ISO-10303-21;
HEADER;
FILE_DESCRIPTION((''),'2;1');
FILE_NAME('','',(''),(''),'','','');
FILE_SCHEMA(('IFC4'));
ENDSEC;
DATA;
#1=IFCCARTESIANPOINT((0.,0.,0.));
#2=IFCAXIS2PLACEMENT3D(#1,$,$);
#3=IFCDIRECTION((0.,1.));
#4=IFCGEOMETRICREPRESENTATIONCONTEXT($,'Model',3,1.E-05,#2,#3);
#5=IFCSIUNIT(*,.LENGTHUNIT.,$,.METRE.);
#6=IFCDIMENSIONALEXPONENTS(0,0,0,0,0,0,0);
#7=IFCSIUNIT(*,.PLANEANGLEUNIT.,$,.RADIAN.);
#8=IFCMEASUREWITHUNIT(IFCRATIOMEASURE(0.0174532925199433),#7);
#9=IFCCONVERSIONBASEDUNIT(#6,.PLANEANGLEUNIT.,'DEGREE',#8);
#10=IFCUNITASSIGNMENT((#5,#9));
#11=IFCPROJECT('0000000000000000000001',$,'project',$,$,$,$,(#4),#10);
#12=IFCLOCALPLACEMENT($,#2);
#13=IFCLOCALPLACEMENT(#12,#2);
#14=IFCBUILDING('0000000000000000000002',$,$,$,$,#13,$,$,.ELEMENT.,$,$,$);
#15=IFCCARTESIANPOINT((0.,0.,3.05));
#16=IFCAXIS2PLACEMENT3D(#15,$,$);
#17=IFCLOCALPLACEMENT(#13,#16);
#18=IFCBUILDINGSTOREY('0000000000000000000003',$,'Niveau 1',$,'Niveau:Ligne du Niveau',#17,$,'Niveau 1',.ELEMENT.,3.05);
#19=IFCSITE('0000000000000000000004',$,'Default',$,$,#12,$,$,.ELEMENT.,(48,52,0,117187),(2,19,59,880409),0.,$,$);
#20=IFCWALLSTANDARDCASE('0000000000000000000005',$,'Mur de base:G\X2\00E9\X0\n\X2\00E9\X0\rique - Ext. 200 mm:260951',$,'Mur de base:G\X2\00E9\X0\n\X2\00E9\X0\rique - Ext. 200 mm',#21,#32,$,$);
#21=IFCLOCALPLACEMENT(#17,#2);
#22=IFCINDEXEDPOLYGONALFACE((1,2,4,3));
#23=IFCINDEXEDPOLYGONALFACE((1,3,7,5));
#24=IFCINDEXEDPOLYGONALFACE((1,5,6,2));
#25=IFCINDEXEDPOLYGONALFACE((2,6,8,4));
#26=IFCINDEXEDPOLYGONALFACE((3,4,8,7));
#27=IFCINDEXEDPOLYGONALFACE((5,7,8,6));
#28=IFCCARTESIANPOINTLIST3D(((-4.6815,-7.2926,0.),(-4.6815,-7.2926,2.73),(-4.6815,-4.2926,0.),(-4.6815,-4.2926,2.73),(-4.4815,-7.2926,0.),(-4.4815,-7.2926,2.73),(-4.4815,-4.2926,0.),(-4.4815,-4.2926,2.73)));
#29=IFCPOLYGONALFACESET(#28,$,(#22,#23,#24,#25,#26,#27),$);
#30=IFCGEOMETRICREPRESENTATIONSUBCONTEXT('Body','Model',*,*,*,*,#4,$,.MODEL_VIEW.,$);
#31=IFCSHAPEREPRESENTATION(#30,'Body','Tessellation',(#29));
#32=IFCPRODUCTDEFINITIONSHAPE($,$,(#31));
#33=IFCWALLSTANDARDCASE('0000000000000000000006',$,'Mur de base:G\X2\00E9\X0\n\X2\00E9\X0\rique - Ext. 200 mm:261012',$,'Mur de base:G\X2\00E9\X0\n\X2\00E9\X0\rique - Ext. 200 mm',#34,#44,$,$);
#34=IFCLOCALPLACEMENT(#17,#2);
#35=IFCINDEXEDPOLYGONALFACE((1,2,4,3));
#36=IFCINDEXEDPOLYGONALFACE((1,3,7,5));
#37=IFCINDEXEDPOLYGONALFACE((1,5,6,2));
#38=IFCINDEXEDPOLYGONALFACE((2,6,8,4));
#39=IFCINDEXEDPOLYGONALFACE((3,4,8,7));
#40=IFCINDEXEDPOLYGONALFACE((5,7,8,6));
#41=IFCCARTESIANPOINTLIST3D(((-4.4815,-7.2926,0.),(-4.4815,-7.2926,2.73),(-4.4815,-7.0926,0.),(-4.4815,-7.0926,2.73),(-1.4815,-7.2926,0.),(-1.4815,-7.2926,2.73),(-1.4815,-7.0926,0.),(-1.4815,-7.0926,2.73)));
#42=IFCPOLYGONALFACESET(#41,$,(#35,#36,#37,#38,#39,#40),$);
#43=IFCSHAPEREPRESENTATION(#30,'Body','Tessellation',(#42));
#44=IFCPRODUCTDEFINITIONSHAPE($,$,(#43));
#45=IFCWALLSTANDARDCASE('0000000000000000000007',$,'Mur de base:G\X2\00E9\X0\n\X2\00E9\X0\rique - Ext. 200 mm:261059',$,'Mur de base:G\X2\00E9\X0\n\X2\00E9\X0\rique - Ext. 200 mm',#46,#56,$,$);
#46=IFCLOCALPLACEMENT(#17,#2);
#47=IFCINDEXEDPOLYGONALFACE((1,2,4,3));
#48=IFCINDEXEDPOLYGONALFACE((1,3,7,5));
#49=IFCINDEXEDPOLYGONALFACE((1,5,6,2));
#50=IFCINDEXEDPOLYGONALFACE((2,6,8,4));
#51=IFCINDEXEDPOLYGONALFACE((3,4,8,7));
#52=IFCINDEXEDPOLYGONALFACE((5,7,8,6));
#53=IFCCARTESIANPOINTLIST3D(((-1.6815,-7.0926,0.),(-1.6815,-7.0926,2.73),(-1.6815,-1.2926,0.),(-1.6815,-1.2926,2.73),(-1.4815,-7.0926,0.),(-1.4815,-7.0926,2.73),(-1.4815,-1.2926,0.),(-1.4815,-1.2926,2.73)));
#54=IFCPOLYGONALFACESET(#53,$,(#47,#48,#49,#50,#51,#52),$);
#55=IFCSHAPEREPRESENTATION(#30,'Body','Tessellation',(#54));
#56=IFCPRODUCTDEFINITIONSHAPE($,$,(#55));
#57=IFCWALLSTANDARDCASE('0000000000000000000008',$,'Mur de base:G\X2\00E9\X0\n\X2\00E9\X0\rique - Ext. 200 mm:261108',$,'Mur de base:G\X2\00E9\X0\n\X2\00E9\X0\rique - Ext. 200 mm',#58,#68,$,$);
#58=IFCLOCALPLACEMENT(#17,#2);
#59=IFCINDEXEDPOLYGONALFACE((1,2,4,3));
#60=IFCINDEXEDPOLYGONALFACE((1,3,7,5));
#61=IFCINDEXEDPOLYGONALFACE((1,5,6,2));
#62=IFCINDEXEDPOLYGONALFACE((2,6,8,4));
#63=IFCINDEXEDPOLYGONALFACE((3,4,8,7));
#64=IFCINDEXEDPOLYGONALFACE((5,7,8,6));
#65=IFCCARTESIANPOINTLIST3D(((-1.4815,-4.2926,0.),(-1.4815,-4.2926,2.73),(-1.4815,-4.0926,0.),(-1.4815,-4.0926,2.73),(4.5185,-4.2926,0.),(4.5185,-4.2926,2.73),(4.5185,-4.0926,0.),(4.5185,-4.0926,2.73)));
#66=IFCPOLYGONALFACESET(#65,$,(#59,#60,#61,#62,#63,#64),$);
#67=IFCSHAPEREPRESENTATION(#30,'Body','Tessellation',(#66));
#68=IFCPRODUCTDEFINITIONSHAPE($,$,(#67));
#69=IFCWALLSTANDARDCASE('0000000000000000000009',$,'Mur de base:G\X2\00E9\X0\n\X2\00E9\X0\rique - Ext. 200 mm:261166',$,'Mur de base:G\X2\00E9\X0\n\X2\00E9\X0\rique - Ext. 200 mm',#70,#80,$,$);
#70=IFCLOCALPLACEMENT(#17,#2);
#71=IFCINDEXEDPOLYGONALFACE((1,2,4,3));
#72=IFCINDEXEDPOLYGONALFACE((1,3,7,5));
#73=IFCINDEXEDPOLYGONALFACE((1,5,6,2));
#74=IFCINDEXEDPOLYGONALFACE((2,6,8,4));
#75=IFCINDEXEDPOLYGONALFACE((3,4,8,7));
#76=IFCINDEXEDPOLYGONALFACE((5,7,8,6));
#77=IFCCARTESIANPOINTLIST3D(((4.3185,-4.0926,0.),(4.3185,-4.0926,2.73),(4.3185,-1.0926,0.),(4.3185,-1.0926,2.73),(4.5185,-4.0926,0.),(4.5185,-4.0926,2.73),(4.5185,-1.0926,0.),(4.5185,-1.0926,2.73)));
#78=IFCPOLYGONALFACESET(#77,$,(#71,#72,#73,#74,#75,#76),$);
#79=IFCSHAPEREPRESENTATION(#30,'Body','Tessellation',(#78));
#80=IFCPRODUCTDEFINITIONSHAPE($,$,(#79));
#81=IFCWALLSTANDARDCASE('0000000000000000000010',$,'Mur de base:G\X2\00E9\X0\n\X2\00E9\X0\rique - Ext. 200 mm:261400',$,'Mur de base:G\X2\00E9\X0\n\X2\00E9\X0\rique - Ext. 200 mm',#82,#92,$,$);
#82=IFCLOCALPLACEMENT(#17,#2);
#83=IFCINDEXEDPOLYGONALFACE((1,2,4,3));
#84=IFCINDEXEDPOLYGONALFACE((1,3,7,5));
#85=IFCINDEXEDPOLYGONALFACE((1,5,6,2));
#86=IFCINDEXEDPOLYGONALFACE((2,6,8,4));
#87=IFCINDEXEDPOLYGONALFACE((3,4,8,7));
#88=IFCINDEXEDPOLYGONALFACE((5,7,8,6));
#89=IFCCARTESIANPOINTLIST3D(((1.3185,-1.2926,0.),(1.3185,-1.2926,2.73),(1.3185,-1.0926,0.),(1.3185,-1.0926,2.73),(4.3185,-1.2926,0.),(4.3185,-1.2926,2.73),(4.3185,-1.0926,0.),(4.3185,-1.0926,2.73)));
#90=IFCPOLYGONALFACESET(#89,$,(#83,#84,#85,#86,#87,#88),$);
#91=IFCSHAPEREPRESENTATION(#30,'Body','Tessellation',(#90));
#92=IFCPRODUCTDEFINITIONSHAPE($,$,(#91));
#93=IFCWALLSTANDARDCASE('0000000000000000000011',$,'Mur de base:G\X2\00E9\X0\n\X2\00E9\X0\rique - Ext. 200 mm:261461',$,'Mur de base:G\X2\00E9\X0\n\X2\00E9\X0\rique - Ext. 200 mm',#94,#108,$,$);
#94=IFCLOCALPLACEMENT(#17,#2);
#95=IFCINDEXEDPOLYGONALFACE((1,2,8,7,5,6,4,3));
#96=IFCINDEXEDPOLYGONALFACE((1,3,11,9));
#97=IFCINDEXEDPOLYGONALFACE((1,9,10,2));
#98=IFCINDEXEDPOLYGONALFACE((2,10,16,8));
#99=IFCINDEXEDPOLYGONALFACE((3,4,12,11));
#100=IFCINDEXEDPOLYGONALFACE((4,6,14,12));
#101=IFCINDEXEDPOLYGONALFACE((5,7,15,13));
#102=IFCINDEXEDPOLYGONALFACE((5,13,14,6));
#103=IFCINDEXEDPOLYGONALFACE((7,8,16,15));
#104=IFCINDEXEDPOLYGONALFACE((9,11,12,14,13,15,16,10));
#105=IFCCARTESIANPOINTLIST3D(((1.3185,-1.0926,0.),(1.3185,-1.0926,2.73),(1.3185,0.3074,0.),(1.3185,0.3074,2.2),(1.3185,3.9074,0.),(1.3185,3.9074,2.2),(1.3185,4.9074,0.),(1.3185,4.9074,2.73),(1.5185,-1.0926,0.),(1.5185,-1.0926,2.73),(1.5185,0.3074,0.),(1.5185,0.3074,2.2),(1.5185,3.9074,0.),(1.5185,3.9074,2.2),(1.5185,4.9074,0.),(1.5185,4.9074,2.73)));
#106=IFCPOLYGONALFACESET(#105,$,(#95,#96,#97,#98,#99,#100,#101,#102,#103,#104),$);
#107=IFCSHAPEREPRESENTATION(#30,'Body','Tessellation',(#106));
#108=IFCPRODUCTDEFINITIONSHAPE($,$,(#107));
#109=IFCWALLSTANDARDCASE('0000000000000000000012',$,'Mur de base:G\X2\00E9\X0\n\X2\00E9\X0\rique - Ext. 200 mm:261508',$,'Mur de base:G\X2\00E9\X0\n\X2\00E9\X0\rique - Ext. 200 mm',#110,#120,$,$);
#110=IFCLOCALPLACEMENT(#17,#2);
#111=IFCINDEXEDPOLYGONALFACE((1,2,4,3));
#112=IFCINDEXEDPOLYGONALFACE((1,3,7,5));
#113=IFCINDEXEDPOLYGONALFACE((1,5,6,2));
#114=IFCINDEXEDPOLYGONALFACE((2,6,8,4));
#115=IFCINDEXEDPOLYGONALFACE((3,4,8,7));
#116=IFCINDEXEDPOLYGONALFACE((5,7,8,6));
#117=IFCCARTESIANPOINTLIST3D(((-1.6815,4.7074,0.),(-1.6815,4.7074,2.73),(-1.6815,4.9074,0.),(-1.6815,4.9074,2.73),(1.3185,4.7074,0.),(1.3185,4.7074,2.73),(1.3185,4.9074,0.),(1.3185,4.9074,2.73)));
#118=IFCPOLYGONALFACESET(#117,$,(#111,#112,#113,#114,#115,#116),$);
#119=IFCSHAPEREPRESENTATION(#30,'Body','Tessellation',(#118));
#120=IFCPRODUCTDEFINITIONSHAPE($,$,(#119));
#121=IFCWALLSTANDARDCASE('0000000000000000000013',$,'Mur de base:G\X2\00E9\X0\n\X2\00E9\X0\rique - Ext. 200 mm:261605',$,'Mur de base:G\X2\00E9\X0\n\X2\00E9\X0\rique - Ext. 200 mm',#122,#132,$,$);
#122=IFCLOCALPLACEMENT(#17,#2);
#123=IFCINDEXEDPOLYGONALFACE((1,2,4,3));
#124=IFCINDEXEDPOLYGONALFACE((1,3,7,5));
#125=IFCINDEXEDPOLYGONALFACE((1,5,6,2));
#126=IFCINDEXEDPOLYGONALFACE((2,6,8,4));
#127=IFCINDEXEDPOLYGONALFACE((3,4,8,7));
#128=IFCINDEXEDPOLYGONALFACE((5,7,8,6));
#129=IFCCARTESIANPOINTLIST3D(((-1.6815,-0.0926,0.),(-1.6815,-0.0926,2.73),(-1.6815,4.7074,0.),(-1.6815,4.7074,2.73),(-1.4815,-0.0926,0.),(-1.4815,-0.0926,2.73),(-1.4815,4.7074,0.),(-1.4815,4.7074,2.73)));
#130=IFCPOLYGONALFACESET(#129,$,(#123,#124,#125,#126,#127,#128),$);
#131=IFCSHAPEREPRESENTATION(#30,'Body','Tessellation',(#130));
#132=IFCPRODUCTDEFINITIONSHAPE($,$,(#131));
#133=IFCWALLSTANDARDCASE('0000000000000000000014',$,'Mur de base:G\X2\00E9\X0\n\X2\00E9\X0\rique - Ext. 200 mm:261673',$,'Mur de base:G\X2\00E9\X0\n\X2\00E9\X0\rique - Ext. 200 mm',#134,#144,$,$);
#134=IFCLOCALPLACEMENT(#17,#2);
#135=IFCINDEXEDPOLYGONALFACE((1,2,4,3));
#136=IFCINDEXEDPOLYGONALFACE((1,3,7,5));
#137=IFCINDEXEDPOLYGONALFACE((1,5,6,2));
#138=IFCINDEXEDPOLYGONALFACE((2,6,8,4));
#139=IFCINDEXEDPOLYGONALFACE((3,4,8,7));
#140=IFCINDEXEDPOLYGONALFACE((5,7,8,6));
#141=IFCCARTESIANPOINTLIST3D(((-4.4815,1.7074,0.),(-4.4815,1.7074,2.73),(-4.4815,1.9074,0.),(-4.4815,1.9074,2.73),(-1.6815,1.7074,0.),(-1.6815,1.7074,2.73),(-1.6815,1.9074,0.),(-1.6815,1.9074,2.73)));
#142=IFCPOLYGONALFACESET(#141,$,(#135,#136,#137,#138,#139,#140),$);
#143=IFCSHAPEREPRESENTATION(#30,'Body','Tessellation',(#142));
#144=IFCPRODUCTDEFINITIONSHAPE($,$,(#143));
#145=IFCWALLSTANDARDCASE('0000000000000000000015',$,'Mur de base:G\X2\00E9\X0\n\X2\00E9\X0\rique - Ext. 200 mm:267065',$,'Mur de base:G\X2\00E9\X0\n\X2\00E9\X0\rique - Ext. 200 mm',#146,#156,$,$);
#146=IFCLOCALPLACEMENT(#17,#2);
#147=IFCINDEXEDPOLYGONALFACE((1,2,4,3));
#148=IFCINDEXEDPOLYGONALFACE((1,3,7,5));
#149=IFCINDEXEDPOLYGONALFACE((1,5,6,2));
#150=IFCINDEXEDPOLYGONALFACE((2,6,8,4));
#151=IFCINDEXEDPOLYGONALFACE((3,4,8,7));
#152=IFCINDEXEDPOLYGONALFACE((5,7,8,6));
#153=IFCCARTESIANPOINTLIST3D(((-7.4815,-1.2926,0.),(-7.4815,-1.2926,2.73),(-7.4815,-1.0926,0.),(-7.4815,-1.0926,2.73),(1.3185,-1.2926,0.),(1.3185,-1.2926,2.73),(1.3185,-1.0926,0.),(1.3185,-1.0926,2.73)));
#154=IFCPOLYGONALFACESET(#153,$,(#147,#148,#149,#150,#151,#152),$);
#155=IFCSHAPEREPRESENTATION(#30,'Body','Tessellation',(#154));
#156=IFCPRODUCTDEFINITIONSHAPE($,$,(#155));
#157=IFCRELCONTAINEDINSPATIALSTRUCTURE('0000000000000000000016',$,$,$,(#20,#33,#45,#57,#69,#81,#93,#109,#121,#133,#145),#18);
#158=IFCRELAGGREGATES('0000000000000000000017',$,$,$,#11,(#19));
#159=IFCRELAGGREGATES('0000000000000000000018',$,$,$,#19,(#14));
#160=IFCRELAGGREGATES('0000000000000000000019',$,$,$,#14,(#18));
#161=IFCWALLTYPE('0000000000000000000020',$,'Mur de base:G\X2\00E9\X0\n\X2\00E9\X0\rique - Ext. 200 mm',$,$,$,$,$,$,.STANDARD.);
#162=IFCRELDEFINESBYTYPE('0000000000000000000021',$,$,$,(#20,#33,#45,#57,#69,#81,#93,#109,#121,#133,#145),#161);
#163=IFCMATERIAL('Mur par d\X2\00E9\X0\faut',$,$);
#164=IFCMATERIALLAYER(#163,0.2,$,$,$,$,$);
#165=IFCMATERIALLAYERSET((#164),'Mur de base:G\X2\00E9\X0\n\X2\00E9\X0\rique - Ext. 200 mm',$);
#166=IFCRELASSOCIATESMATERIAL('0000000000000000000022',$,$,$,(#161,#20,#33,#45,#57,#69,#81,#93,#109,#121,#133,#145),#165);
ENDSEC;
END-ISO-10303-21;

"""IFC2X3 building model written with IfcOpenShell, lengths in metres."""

from ifc_helpers import new_model, entity, si_unit, converted_unit, direction, frame, frame_2d, origin, place, context, subcontext, project, spatial, polyline, rectangle, extrude, clip, bounded_halfspace, material, layer, layer_set, layer_usage, type_object, element, save


model = new_model("IFC2X3")

# Units and contexts
model_context = context("Model", 3, precision=1e-05, world=origin(), true_north=direction((0.0, 1.0)))
body_context = subcontext(model_context, "Body", "Model", "MODEL_VIEW")
ifc_project = project(units=[si_unit("LENGTHUNIT", "METRE"), converted_unit("PLANEANGLEUNIT", "DEGREE", entity("IfcRatioMeasure", 0.0174532925199433), si_unit("PLANEANGLEUNIT", "RADIAN"), dimensions=[0, 0, 0, 0, 0, 0, 0])], contexts=[model_context])

# Site, building, storey
site_placement = place(None, origin())
site = spatial("IfcSite", under=ifc_project, at=site_placement, Name="Default", CompositionType="ELEMENT", RefLatitude=(48, 52, 0, 117187), RefLongitude=(2, 19, 59, 880409), RefElevation=0.0)
building_placement = place(site_placement, origin())
building = spatial("IfcBuilding", under=site, at=building_placement, CompositionType="ELEMENT")
storey_placement = place(building_placement, frame((0.0, 0.0, 3.05)))
storey = spatial("IfcBuildingStorey", under=building, at=storey_placement, Name="Niveau 1", ObjectType="Niveau:Ligne du Niveau", LongName="Niveau 1", CompositionType="ELEMENT", Elevation=3.05)

# Walls
ifc_material_1 = material(Name="Mur par défaut")
ifc_layer_1 = layer(ifc_material_1, 0.2)
ifc_layer_set_1 = layer_set([ifc_layer_1], Name="Mur de base:Générique - Ext. 200 mm")
wall_type = type_object("IfcWallType", Name="Mur de base:Générique - Ext. 200 mm", PredefinedType="STANDARD", material=ifc_layer_set_1)
ifc_layer_usage_1 = layer_usage(ifc_layer_set_1, "AXIS2", "NEGATIVE", 0.1)
wall_1_placement = place(storey_placement, frame((-4.5815, -4.2926, 0.0), z_axis=(0.0, 0.0, 1.0), x_axis=(0.0, -1.0, 0.0)))
element("IfcWallStandardCase", 1, at=wall_1_placement, inside=storey, type_object=wall_type, material=ifc_layer_usage_1, Name="Mur de base:Générique - Ext. 200 mm:260951", ObjectType="Mur de base:Générique - Ext. 200 mm", context=body_context, shape_type="Clipping", body=[
    clip(extrude(rectangle(XDim=3.0, YDim=0.2, at=frame_2d((1.5, 0.0), x_axis=(-1.0, 0.0))), origin(), (0.0, 0.0, 1.0), 2.73), bounded_halfspace(frame((0.0, -0.1, 2.73), z_axis=(0.0, 0.0, -1.0), x_axis=(0.0, 1.0, 0.0)), True, frame((0.0, -0.1, 2.73)), polyline([(0.0, 0.0), (3.0, 0.0), (3.0, 0.2), (2.8, 0.2), (0.0, 0.2), (0.0, 0.0)]))),
])
ifc_layer_usage_2 = layer_usage(ifc_layer_set_1, "AXIS2", "NEGATIVE", 0.1)
wall_2_placement = place(storey_placement, frame((-4.4815, -7.1926, 0.0)))
element("IfcWallStandardCase", 2, at=wall_2_placement, inside=storey, type_object=wall_type, material=ifc_layer_usage_2, Name="Mur de base:Générique - Ext. 200 mm:261012", ObjectType="Mur de base:Générique - Ext. 200 mm", context=body_context, shape_type="Clipping", body=[
    clip(extrude(rectangle(XDim=3.0, YDim=0.2, at=frame_2d((1.5, 0.0), x_axis=(-1.0, 0.0))), origin(), (0.0, 0.0, 1.0), 2.73), bounded_halfspace(frame((0.0, -0.1, 2.73), z_axis=(0.0, 0.0, -1.0), x_axis=(1.0, 0.0, 0.0)), True, frame((0.0, -0.1, 2.73)), polyline([(0.0, 0.0), (3.0, 0.0), (3.0, 0.2), (2.8, 0.2), (0.0, 0.2), (0.0, 0.0)]))),
])
ifc_layer_usage_3 = layer_usage(ifc_layer_set_1, "AXIS2", "NEGATIVE", 0.1)
wall_3_placement = place(storey_placement, frame((-1.5815, -7.0926, 0.0), z_axis=(0.0, 0.0, 1.0), x_axis=(0.0, 1.0, 0.0)))
element("IfcWallStandardCase", 3, at=wall_3_placement, inside=storey, type_object=wall_type, material=ifc_layer_usage_3, Name="Mur de base:Générique - Ext. 200 mm:261059", ObjectType="Mur de base:Générique - Ext. 200 mm", context=body_context, shape_type="Clipping", body=[
    clip(extrude(rectangle(XDim=5.8, YDim=0.2, at=frame_2d((2.9, 0.0), x_axis=(-1.0, 0.0))), origin(), (0.0, 0.0, 1.0), 2.73), bounded_halfspace(frame((0.0, -0.1, 2.73), z_axis=(0.0, 0.0, -1.0), x_axis=(0.0, -1.0, 0.0)), True, frame((0.0, -0.1, 2.73)), polyline([(0.0, 0.0), (2.6633, 0.0), (2.8, 0.0), (3.0, 0.0), (5.8, 0.0), (5.8, 0.2), (0.0, 0.2), (0.0, 0.0)]))),
])
ifc_layer_usage_4 = layer_usage(ifc_layer_set_1, "AXIS2", "NEGATIVE", 0.1)
wall_4_placement = place(storey_placement, frame((-1.4815, -4.1926, 0.0)))
element("IfcWallStandardCase", 4, at=wall_4_placement, inside=storey, type_object=wall_type, material=ifc_layer_usage_4, Name="Mur de base:Générique - Ext. 200 mm:261108", ObjectType="Mur de base:Générique - Ext. 200 mm", context=body_context, shape_type="Clipping", body=[
    clip(extrude(rectangle(XDim=6.0, YDim=0.2, at=frame_2d((3.0, 0.0), x_axis=(-1.0, 0.0))), origin(), (0.0, 0.0, 1.0), 2.73), bounded_halfspace(frame((0.0, -0.1, 2.73), z_axis=(0.0, 0.0, -1.0), x_axis=(1.0, 0.0, 0.0)), True, frame((0.0, -0.1, 2.73)), polyline([(0.0, 0.0), (1.0152, 0.0), (6.0, 0.0), (6.0, 0.2), (5.8, 0.2), (0.0, 0.2), (0.0, 0.0)]))),
])
ifc_layer_usage_5 = layer_usage(ifc_layer_set_1, "AXIS2", "NEGATIVE", 0.1)
wall_5_placement = place(storey_placement, frame((4.4185, -4.0926, 0.0), z_axis=(0.0, 0.0, 1.0), x_axis=(0.0, 1.0, 0.0)))
element("IfcWallStandardCase", 5, at=wall_5_placement, inside=storey, type_object=wall_type, material=ifc_layer_usage_5, Name="Mur de base:Générique - Ext. 200 mm:261166", ObjectType="Mur de base:Générique - Ext. 200 mm", context=body_context, shape_type="Clipping", body=[
    clip(extrude(rectangle(XDim=3.0, YDim=0.2, at=frame_2d((1.5, 0.0), x_axis=(-1.0, 0.0))), origin(), (0.0, 0.0, 1.0), 2.73), bounded_halfspace(frame((0.0, -0.1, 2.73), z_axis=(0.0, 0.0, -1.0), x_axis=(0.0, -1.0, 0.0)), True, frame((0.0, -0.1, 2.73)), polyline([(0.0, 0.0), (3.0, 0.0), (3.0, 0.2), (2.8, 0.2), (0.0, 0.2), (0.0, 0.0)]))),
])
ifc_layer_usage_6 = layer_usage(ifc_layer_set_1, "AXIS2", "NEGATIVE", 0.1)
wall_6_placement = place(storey_placement, frame((4.3185, -1.1926, 0.0), z_axis=(0.0, 0.0, 1.0), x_axis=(-1.0, 0.0, 0.0)))
element("IfcWallStandardCase", 6, at=wall_6_placement, inside=storey, type_object=wall_type, material=ifc_layer_usage_6, Name="Mur de base:Générique - Ext. 200 mm:261400", ObjectType="Mur de base:Générique - Ext. 200 mm", context=body_context, shape_type="Clipping", body=[
    clip(extrude(rectangle(XDim=3.0, YDim=0.2, at=frame_2d((1.5, 0.0), x_axis=(-1.0, 0.0))), origin(), (0.0, 0.0, 1.0), 2.73), bounded_halfspace(frame((0.0, -0.1, 2.73), z_axis=(0.0, 0.0, -1.0), x_axis=(-1.0, 0.0, 0.0)), True, frame((0.0, -0.1, 2.73)), polyline([(0.0, 0.0), (2.8, 0.0), (3.0, 0.0), (3.0, 0.2), (0.0, 0.2), (0.0, 0.0)]))),
])

# Wall, opening
ifc_layer_usage_7 = layer_usage(ifc_layer_set_1, "AXIS2", "NEGATIVE", 0.1)
wall_7_placement = place(storey_placement, frame((1.4185, -1.0926, 0.0), z_axis=(0.0, 0.0, 1.0), x_axis=(0.0, 1.0, 0.0)))
wall_7 = element("IfcWallStandardCase", 7, at=wall_7_placement, inside=storey, type_object=wall_type, material=ifc_layer_usage_7, Name="Mur de base:Générique - Ext. 200 mm:261461", ObjectType="Mur de base:Générique - Ext. 200 mm", context=body_context, shape_type="Clipping", body=[
    clip(extrude(rectangle(XDim=6.0, YDim=0.2, at=frame_2d((3.0, 0.0), x_axis=(-1.0, 0.0))), origin(), (0.0, 0.0, 1.0), 2.73), bounded_halfspace(frame((0.0, -0.1, 2.73), z_axis=(0.0, 0.0, -1.0), x_axis=(0.0, -1.0, 0.0)), True, frame((0.0, -0.1, 2.73)), polyline([(0.0, 0.0), (6.0, 0.0), (6.0, 0.2), (5.8, 0.2), (0.0, 0.2), (0.0, 0.0)]))),
])
opening_1_placement = place(wall_7_placement, origin())
element("IfcOpeningElement", 8, at=opening_1_placement, cuts=wall_7, ObjectType="Opening", context=body_context, shape_type="SweptSolid", body=[
    extrude(rectangle(XDim=2.2, YDim=3.6, at=frame_2d((0.0, 0.0), x_axis=(0.0, 1.0))), frame((3.2, -0.2524, 1.1), z_axis=(0.0, 1.0, 0.0), x_axis=(-1.0, 0.0, 0.0)), (0.0, 0.0, 1.0), 0.5048),
])

# Walls
ifc_layer_usage_8 = layer_usage(ifc_layer_set_1, "AXIS2", "NEGATIVE", 0.1)
wall_8_placement = place(storey_placement, frame((1.3185, 4.8074, 0.0), z_axis=(0.0, 0.0, 1.0), x_axis=(-1.0, 0.0, 0.0)))
element("IfcWallStandardCase", 9, at=wall_8_placement, inside=storey, type_object=wall_type, material=ifc_layer_usage_8, Name="Mur de base:Générique - Ext. 200 mm:261508", ObjectType="Mur de base:Générique - Ext. 200 mm", context=body_context, shape_type="Clipping", body=[
    clip(extrude(rectangle(XDim=3.0, YDim=0.2, at=frame_2d((1.5, 0.0), x_axis=(-1.0, 0.0))), origin(), (0.0, 0.0, 1.0), 2.73), bounded_halfspace(frame((0.0, -0.1, 2.73), z_axis=(0.0, 0.0, -1.0), x_axis=(-1.0, 0.0, 0.0)), True, frame((0.0, -0.1, 2.73)), polyline([(0.0, 0.0), (3.0, 0.0), (3.0, 0.2), (2.8, 0.2), (0.0, 0.2), (0.0, 0.0)]))),
])
ifc_layer_usage_9 = layer_usage(ifc_layer_set_1, "AXIS2", "NEGATIVE", 0.1)
wall_9_placement = place(storey_placement, frame((-1.5815, 4.7074, 0.0), z_axis=(0.0, 0.0, 1.0), x_axis=(0.0, -1.0, 0.0)))
element("IfcWallStandardCase", 10, at=wall_9_placement, inside=storey, type_object=wall_type, material=ifc_layer_usage_9, Name="Mur de base:Générique - Ext. 200 mm:261605", ObjectType="Mur de base:Générique - Ext. 200 mm", context=body_context, shape_type="Clipping", body=[
    clip(extrude(rectangle(XDim=4.8, YDim=0.2, at=frame_2d((2.4, 0.0), x_axis=(-1.0, 0.0))), origin(), (0.0, 0.0, 1.0), 2.73), bounded_halfspace(frame((0.0, -0.1, 2.73), z_axis=(0.0, 0.0, -1.0), x_axis=(0.0, 1.0, 0.0)), True, frame((0.0, -0.1, 2.73)), polyline([(0.0, 0.0), (2.8, 0.0), (3.0, 0.0), (4.8, 0.0), (4.8, 0.2), (4.6, 0.2), (0.0, 0.2), (0.0, 0.0)]))),
])
ifc_layer_usage_10 = layer_usage(ifc_layer_set_1, "AXIS2", "NEGATIVE", 0.1)
wall_10_placement = place(storey_placement, frame((-1.6815, 1.8074, 0.0), z_axis=(0.0, 0.0, 1.0), x_axis=(-1.0, 0.0, 0.0)))
element("IfcWallStandardCase", 11, at=wall_10_placement, inside=storey, type_object=wall_type, material=ifc_layer_usage_10, Name="Mur de base:Générique - Ext. 200 mm:261673", ObjectType="Mur de base:Générique - Ext. 200 mm", context=body_context, shape_type="Clipping", body=[
    clip(extrude(rectangle(XDim=2.8, YDim=0.2, at=frame_2d((1.4, 0.0), x_axis=(-1.0, 0.0))), origin(), (0.0, 0.0, 1.0), 2.73), bounded_halfspace(frame((0.0, -0.1, 2.73), z_axis=(0.0, 0.0, -1.0), x_axis=(-1.0, 0.0, 0.0)), True, frame((0.0, -0.1, 2.73)), polyline([(0.0, 0.0), (2.8, 0.0), (2.8, 0.2), (0.0, 0.2), (0.0, 0.0)]))),
])
ifc_layer_usage_11 = layer_usage(ifc_layer_set_1, "AXIS2", "NEGATIVE", 0.1)
wall_11_placement = place(storey_placement, frame((-7.4815, -1.1926, 0.0)))
element("IfcWallStandardCase", 12, at=wall_11_placement, inside=storey, type_object=wall_type, material=ifc_layer_usage_11, Name="Mur de base:Générique - Ext. 200 mm:267065", ObjectType="Mur de base:Générique - Ext. 200 mm", context=body_context, shape_type="Clipping", body=[
    clip(extrude(rectangle(XDim=8.8, YDim=0.2, at=frame_2d((4.4, 0.0), x_axis=(-1.0, 0.0))), origin(), (0.0, 0.0, 1.0), 2.73), bounded_halfspace(frame((0.0, -0.1, 2.73), z_axis=(0.0, 0.0, -1.0), x_axis=(1.0, 0.0, 0.0)), True, frame((0.0, -0.1, 2.73)), polyline([(0.0, 0.0), (5.8, 0.0), (6.0, 0.0), (8.8, 0.0), (8.8, 0.2), (7.1, 0.2), (6.9, 0.2), (3.0, 0.2), (2.8, 0.2), (0.0, 0.2), (0.0, 0.0)]))),
])

save(model, "model.ifc")
